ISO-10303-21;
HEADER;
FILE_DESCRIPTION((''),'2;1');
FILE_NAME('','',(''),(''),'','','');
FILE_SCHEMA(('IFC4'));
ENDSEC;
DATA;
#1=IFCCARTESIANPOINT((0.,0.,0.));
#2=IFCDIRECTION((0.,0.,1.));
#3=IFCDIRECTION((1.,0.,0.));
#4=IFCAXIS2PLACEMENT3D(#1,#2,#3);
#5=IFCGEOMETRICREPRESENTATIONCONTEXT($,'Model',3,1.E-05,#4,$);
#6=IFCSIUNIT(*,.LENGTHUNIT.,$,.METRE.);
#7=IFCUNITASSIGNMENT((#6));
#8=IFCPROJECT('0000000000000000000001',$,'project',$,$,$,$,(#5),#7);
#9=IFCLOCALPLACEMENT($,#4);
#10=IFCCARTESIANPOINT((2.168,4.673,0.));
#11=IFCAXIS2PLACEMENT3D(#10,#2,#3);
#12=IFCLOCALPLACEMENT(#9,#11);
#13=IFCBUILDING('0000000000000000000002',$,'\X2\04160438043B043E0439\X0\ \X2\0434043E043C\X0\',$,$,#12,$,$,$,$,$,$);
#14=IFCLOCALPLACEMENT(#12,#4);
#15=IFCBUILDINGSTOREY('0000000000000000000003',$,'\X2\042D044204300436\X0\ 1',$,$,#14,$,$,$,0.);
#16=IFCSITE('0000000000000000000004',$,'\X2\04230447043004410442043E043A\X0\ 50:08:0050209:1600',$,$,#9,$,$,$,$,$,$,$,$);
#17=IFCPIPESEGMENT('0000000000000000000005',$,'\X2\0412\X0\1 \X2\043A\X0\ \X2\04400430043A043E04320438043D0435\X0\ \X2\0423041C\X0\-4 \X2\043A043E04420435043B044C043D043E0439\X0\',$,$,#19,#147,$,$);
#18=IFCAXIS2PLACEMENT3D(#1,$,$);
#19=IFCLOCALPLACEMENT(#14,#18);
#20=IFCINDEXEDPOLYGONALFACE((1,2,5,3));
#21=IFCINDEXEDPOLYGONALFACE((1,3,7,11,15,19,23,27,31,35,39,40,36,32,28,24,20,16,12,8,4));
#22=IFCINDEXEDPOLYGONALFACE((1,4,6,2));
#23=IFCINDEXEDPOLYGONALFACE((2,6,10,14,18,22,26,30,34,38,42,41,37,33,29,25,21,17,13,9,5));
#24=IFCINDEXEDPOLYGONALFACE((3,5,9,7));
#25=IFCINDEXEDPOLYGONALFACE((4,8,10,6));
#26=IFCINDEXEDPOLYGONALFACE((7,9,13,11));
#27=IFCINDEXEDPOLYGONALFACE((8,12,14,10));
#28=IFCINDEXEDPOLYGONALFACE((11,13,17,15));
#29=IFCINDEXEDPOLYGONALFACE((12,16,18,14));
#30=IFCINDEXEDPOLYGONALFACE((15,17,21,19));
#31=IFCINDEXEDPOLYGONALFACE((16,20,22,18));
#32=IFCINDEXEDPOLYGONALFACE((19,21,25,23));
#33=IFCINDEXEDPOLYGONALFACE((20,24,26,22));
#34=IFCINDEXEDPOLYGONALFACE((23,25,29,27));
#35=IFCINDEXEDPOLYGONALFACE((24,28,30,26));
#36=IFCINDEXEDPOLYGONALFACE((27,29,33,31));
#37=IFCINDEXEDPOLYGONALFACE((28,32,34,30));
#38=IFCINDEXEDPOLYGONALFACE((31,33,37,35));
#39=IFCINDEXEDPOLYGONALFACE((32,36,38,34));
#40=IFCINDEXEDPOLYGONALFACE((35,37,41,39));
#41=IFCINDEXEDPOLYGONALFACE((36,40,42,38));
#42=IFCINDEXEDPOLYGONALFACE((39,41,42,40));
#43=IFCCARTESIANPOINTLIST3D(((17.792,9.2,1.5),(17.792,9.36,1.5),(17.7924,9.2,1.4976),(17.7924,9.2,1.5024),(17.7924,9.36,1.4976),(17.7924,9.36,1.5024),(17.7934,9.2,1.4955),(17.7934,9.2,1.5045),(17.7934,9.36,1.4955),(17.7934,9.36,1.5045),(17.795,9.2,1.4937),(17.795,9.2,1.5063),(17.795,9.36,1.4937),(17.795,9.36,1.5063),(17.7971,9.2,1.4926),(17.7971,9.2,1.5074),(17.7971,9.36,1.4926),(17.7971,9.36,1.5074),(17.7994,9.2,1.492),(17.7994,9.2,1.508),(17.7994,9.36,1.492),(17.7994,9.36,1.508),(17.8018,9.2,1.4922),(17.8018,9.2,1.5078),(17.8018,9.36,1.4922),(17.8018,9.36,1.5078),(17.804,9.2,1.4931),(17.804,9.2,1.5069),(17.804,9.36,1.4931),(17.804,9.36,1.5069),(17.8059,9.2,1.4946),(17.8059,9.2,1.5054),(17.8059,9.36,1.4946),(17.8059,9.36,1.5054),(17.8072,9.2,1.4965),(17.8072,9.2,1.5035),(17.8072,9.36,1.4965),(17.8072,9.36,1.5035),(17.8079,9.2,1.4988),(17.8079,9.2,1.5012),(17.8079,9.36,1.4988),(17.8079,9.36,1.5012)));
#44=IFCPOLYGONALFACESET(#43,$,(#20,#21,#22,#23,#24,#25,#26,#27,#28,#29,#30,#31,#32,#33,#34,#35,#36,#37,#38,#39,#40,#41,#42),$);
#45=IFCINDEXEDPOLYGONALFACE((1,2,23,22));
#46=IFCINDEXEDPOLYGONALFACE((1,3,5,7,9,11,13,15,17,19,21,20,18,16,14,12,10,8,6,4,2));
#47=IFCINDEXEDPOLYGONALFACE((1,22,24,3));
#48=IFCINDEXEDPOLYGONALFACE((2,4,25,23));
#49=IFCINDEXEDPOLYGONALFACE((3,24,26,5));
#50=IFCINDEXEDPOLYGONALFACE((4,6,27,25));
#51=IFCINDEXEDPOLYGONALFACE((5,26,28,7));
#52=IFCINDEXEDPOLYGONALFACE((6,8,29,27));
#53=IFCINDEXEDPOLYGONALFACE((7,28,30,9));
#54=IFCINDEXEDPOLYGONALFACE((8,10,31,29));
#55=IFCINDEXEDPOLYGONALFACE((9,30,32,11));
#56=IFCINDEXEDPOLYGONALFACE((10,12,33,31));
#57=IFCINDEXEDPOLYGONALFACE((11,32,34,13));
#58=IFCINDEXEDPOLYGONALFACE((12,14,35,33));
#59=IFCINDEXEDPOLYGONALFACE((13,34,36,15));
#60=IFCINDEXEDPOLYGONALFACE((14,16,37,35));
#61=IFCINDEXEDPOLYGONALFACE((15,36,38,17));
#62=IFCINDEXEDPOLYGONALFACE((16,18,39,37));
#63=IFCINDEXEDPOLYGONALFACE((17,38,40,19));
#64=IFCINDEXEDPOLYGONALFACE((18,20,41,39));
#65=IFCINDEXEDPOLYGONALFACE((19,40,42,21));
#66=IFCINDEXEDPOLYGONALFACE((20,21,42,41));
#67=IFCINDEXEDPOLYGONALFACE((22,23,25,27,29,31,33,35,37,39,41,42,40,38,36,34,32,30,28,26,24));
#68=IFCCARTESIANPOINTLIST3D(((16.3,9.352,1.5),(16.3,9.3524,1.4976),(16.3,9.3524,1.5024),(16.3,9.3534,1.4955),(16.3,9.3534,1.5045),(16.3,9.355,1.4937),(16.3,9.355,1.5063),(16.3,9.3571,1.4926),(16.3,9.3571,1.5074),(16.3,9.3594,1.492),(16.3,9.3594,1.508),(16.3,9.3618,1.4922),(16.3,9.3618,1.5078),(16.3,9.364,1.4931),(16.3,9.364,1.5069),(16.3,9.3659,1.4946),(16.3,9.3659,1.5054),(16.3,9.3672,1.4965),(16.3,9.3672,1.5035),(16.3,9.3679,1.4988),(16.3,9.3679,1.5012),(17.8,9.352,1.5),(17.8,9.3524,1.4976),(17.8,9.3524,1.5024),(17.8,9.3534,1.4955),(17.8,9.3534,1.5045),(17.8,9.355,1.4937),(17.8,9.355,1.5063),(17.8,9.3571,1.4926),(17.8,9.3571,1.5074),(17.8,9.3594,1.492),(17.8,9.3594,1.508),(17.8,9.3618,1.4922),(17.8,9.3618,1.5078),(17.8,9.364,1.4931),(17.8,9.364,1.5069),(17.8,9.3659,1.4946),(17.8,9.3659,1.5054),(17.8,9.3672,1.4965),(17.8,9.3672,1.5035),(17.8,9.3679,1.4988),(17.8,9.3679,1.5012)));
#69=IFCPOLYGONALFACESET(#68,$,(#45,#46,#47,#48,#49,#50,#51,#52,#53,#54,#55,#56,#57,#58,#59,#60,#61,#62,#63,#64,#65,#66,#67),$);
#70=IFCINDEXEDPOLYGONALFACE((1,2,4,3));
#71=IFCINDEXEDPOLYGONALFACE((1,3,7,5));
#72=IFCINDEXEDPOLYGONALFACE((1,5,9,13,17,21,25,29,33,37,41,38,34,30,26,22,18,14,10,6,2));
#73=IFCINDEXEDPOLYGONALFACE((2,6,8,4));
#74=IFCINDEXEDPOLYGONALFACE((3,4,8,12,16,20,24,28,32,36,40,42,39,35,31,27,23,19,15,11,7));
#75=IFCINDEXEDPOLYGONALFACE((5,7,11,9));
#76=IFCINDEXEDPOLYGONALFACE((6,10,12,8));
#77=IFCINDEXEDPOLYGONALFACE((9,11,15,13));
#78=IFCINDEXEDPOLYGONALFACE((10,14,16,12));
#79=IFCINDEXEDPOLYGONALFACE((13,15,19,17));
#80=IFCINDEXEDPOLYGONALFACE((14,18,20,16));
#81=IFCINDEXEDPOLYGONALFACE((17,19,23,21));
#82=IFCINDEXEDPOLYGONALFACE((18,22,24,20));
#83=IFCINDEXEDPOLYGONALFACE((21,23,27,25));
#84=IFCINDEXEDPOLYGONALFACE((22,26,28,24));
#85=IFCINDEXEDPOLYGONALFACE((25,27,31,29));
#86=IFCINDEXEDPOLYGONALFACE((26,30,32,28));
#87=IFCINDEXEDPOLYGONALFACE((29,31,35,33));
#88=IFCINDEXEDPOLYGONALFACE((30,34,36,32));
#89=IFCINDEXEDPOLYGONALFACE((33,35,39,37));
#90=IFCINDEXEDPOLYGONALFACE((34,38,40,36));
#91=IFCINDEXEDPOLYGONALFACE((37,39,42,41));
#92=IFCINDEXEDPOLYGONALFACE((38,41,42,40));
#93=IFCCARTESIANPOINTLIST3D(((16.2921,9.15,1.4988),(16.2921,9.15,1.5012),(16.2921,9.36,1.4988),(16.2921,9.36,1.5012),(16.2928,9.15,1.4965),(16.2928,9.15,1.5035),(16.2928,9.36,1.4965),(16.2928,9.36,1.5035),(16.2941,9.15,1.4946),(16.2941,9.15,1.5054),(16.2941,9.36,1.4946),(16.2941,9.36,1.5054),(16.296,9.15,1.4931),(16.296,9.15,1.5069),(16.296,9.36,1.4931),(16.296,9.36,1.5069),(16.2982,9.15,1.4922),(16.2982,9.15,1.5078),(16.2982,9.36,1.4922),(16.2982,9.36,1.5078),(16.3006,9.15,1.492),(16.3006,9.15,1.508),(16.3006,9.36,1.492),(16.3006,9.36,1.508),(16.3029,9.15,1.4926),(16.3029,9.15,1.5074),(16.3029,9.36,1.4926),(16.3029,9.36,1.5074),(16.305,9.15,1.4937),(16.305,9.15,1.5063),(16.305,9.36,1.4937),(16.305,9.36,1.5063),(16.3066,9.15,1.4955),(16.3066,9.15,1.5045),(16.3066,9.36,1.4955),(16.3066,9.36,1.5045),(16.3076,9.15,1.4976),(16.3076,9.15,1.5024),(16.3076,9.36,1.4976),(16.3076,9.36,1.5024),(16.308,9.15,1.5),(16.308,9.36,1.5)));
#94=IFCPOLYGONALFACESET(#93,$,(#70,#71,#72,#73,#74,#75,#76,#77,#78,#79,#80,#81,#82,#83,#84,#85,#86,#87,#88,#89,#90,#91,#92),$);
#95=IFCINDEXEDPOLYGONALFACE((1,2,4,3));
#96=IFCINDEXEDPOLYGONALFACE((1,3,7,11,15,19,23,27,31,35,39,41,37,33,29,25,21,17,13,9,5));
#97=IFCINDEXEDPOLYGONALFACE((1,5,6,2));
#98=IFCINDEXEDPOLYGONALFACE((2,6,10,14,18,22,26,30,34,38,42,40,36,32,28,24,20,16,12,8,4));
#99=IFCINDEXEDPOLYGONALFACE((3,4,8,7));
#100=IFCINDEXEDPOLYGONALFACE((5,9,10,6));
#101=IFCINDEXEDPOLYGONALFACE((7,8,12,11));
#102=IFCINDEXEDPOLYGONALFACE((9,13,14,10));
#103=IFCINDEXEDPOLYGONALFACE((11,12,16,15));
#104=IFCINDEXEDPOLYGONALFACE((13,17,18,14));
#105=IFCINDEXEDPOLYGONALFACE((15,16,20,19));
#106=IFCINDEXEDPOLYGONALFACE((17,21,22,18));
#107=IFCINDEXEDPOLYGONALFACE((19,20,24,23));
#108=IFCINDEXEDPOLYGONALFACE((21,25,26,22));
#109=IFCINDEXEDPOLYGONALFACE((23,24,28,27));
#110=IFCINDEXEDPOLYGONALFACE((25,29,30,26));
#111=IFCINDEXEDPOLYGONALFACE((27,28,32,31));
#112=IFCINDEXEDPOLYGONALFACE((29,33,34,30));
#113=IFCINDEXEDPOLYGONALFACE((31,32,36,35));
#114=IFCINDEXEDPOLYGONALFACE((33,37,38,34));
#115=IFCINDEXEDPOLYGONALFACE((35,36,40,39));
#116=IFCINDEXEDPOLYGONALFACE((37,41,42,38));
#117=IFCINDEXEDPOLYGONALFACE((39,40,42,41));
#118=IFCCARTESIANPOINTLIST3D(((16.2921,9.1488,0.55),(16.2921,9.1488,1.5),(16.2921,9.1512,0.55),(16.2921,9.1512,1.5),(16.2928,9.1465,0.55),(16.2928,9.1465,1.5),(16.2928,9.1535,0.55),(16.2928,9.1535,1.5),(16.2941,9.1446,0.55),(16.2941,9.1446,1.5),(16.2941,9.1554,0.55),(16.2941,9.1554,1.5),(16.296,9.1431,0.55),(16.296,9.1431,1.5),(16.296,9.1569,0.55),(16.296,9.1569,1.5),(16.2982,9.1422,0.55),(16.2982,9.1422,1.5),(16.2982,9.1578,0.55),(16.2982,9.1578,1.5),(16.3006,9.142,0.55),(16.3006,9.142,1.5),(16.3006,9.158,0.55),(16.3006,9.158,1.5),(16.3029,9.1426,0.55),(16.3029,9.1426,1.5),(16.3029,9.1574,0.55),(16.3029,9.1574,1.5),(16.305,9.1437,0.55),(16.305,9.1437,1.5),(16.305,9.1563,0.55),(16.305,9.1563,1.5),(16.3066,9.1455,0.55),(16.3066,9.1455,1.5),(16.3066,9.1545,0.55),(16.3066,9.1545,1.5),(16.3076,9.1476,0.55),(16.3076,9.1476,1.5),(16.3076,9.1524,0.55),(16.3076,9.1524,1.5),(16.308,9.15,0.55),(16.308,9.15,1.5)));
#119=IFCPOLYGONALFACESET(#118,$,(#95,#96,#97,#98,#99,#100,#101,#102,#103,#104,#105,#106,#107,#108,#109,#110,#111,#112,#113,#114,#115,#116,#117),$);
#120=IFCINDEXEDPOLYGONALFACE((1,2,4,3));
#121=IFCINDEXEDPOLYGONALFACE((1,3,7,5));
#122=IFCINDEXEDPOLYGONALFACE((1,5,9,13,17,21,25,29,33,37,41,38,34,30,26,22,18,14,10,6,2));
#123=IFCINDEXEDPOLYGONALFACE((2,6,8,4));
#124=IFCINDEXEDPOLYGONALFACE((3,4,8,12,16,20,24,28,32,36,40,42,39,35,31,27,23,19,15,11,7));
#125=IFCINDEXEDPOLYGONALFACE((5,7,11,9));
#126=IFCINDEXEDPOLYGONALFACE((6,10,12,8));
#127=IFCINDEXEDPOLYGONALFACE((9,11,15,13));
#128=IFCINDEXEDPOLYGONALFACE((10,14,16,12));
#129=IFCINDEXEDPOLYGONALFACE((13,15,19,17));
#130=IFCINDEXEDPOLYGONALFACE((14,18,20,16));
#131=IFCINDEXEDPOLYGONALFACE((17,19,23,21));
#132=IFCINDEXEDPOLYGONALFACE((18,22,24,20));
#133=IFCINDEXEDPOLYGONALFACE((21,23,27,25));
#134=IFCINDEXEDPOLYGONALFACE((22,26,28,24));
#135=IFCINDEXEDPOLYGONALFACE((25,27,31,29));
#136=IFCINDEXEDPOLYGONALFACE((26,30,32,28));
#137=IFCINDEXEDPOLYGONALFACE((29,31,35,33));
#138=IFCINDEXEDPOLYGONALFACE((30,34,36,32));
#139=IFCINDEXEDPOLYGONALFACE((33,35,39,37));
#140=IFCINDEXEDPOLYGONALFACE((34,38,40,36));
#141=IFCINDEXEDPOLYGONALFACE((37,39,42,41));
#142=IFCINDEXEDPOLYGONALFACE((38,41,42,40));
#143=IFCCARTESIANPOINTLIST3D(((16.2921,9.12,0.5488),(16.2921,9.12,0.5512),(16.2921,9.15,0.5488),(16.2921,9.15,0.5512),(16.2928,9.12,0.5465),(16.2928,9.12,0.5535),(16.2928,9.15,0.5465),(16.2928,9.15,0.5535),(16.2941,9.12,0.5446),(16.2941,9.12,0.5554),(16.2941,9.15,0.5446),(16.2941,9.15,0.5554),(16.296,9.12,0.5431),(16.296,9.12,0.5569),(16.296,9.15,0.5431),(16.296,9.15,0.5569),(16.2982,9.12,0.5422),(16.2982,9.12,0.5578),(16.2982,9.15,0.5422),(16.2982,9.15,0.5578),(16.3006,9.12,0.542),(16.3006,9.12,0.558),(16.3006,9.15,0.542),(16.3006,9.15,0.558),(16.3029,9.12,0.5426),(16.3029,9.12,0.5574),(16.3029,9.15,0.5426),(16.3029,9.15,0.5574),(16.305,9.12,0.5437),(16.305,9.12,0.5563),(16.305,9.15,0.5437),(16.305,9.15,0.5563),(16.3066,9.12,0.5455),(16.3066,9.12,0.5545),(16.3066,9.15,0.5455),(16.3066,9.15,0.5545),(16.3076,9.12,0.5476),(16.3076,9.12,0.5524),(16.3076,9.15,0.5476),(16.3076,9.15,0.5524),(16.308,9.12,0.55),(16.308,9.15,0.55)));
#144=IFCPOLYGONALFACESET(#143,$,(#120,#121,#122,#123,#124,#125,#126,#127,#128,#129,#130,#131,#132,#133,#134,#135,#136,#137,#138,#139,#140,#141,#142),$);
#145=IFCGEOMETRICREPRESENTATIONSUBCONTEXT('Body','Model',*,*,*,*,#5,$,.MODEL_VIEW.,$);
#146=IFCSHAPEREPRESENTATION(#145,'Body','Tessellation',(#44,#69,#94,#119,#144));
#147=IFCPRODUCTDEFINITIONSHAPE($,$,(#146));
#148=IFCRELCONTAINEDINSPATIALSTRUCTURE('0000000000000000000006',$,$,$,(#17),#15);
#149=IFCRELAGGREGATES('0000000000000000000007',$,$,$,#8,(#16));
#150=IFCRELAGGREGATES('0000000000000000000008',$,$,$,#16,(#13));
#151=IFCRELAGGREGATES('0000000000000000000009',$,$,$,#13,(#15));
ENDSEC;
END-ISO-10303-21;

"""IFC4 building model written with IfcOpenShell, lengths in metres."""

from ifc_helpers import new_model, si_unit, frame, origin_with_axes, origin_2d, place, context, subcontext, project, spatial, circle, extrude, element, save


model = new_model("IFC4")

# Units and contexts
model_context = context("Model", 3, precision=1e-05, world=origin_with_axes())
body_context = subcontext(model_context, "Body", "Model", "MODEL_VIEW")
ifc_project = project(units=[si_unit("LENGTHUNIT", "METRE")], contexts=[model_context])

# Site, building, storey
site_placement = place(None, origin_with_axes())
site = spatial("IfcSite", under=ifc_project, at=site_placement, Name="Участок 50:08:0050209:1600")
building_placement = place(site_placement, frame((2.168, 4.673, 0.0), z_axis=(0.0, 0.0, 1.0), x_axis=(1.0, 0.0, 0.0)))
building = spatial("IfcBuilding", under=site, at=building_placement, Name="Жилой дом")
storey_placement = place(building_placement, origin_with_axes())
storey = spatial("IfcBuildingStorey", under=building, at=storey_placement, Name="Этаж 1", Elevation=0.0)

# Pipe segment
pipe_segment_1_placement = place(storey_placement, origin_with_axes())
element("IfcPipeSegment", 1, at=pipe_segment_1_placement, inside=storey, Name="В1 к раковине УМ-4 котельной", context=body_context, shape_type="SweptSolid", body=[
    extrude(circle(Radius=0.008, at=origin_2d()), frame((17.8, 9.2, 1.5), z_axis=(0.0, 1.0, 0.0), x_axis=(-1.0, 0.0, 0.0)), (0.0, 0.0, 1.0), 0.16),
    extrude(circle(Radius=0.008, at=origin_2d()), frame((17.8, 9.36, 1.5), z_axis=(-1.0, 0.0, 0.0), x_axis=(0.0, -1.0, 0.0)), (0.0, 0.0, 1.0), 1.5),
    extrude(circle(Radius=0.008, at=origin_2d()), frame((16.3, 9.36, 1.5), z_axis=(0.0, -1.0, 0.0), x_axis=(1.0, 0.0, 0.0)), (0.0, 0.0, 1.0), 0.21),
    extrude(circle(Radius=0.008, at=origin_2d()), frame((16.3, 9.15, 1.5), z_axis=(0.0, 0.0, -1.0), x_axis=(1.0, 0.0, 0.0)), (0.0, 0.0, 1.0), 0.95),
    extrude(circle(Radius=0.008, at=origin_2d()), frame((16.3, 9.15, 0.55), z_axis=(0.0, -1.0, 0.0), x_axis=(1.0, 0.0, 0.0)), (0.0, 0.0, 1.0), 0.03),
])

save(model, "model.ifc")
